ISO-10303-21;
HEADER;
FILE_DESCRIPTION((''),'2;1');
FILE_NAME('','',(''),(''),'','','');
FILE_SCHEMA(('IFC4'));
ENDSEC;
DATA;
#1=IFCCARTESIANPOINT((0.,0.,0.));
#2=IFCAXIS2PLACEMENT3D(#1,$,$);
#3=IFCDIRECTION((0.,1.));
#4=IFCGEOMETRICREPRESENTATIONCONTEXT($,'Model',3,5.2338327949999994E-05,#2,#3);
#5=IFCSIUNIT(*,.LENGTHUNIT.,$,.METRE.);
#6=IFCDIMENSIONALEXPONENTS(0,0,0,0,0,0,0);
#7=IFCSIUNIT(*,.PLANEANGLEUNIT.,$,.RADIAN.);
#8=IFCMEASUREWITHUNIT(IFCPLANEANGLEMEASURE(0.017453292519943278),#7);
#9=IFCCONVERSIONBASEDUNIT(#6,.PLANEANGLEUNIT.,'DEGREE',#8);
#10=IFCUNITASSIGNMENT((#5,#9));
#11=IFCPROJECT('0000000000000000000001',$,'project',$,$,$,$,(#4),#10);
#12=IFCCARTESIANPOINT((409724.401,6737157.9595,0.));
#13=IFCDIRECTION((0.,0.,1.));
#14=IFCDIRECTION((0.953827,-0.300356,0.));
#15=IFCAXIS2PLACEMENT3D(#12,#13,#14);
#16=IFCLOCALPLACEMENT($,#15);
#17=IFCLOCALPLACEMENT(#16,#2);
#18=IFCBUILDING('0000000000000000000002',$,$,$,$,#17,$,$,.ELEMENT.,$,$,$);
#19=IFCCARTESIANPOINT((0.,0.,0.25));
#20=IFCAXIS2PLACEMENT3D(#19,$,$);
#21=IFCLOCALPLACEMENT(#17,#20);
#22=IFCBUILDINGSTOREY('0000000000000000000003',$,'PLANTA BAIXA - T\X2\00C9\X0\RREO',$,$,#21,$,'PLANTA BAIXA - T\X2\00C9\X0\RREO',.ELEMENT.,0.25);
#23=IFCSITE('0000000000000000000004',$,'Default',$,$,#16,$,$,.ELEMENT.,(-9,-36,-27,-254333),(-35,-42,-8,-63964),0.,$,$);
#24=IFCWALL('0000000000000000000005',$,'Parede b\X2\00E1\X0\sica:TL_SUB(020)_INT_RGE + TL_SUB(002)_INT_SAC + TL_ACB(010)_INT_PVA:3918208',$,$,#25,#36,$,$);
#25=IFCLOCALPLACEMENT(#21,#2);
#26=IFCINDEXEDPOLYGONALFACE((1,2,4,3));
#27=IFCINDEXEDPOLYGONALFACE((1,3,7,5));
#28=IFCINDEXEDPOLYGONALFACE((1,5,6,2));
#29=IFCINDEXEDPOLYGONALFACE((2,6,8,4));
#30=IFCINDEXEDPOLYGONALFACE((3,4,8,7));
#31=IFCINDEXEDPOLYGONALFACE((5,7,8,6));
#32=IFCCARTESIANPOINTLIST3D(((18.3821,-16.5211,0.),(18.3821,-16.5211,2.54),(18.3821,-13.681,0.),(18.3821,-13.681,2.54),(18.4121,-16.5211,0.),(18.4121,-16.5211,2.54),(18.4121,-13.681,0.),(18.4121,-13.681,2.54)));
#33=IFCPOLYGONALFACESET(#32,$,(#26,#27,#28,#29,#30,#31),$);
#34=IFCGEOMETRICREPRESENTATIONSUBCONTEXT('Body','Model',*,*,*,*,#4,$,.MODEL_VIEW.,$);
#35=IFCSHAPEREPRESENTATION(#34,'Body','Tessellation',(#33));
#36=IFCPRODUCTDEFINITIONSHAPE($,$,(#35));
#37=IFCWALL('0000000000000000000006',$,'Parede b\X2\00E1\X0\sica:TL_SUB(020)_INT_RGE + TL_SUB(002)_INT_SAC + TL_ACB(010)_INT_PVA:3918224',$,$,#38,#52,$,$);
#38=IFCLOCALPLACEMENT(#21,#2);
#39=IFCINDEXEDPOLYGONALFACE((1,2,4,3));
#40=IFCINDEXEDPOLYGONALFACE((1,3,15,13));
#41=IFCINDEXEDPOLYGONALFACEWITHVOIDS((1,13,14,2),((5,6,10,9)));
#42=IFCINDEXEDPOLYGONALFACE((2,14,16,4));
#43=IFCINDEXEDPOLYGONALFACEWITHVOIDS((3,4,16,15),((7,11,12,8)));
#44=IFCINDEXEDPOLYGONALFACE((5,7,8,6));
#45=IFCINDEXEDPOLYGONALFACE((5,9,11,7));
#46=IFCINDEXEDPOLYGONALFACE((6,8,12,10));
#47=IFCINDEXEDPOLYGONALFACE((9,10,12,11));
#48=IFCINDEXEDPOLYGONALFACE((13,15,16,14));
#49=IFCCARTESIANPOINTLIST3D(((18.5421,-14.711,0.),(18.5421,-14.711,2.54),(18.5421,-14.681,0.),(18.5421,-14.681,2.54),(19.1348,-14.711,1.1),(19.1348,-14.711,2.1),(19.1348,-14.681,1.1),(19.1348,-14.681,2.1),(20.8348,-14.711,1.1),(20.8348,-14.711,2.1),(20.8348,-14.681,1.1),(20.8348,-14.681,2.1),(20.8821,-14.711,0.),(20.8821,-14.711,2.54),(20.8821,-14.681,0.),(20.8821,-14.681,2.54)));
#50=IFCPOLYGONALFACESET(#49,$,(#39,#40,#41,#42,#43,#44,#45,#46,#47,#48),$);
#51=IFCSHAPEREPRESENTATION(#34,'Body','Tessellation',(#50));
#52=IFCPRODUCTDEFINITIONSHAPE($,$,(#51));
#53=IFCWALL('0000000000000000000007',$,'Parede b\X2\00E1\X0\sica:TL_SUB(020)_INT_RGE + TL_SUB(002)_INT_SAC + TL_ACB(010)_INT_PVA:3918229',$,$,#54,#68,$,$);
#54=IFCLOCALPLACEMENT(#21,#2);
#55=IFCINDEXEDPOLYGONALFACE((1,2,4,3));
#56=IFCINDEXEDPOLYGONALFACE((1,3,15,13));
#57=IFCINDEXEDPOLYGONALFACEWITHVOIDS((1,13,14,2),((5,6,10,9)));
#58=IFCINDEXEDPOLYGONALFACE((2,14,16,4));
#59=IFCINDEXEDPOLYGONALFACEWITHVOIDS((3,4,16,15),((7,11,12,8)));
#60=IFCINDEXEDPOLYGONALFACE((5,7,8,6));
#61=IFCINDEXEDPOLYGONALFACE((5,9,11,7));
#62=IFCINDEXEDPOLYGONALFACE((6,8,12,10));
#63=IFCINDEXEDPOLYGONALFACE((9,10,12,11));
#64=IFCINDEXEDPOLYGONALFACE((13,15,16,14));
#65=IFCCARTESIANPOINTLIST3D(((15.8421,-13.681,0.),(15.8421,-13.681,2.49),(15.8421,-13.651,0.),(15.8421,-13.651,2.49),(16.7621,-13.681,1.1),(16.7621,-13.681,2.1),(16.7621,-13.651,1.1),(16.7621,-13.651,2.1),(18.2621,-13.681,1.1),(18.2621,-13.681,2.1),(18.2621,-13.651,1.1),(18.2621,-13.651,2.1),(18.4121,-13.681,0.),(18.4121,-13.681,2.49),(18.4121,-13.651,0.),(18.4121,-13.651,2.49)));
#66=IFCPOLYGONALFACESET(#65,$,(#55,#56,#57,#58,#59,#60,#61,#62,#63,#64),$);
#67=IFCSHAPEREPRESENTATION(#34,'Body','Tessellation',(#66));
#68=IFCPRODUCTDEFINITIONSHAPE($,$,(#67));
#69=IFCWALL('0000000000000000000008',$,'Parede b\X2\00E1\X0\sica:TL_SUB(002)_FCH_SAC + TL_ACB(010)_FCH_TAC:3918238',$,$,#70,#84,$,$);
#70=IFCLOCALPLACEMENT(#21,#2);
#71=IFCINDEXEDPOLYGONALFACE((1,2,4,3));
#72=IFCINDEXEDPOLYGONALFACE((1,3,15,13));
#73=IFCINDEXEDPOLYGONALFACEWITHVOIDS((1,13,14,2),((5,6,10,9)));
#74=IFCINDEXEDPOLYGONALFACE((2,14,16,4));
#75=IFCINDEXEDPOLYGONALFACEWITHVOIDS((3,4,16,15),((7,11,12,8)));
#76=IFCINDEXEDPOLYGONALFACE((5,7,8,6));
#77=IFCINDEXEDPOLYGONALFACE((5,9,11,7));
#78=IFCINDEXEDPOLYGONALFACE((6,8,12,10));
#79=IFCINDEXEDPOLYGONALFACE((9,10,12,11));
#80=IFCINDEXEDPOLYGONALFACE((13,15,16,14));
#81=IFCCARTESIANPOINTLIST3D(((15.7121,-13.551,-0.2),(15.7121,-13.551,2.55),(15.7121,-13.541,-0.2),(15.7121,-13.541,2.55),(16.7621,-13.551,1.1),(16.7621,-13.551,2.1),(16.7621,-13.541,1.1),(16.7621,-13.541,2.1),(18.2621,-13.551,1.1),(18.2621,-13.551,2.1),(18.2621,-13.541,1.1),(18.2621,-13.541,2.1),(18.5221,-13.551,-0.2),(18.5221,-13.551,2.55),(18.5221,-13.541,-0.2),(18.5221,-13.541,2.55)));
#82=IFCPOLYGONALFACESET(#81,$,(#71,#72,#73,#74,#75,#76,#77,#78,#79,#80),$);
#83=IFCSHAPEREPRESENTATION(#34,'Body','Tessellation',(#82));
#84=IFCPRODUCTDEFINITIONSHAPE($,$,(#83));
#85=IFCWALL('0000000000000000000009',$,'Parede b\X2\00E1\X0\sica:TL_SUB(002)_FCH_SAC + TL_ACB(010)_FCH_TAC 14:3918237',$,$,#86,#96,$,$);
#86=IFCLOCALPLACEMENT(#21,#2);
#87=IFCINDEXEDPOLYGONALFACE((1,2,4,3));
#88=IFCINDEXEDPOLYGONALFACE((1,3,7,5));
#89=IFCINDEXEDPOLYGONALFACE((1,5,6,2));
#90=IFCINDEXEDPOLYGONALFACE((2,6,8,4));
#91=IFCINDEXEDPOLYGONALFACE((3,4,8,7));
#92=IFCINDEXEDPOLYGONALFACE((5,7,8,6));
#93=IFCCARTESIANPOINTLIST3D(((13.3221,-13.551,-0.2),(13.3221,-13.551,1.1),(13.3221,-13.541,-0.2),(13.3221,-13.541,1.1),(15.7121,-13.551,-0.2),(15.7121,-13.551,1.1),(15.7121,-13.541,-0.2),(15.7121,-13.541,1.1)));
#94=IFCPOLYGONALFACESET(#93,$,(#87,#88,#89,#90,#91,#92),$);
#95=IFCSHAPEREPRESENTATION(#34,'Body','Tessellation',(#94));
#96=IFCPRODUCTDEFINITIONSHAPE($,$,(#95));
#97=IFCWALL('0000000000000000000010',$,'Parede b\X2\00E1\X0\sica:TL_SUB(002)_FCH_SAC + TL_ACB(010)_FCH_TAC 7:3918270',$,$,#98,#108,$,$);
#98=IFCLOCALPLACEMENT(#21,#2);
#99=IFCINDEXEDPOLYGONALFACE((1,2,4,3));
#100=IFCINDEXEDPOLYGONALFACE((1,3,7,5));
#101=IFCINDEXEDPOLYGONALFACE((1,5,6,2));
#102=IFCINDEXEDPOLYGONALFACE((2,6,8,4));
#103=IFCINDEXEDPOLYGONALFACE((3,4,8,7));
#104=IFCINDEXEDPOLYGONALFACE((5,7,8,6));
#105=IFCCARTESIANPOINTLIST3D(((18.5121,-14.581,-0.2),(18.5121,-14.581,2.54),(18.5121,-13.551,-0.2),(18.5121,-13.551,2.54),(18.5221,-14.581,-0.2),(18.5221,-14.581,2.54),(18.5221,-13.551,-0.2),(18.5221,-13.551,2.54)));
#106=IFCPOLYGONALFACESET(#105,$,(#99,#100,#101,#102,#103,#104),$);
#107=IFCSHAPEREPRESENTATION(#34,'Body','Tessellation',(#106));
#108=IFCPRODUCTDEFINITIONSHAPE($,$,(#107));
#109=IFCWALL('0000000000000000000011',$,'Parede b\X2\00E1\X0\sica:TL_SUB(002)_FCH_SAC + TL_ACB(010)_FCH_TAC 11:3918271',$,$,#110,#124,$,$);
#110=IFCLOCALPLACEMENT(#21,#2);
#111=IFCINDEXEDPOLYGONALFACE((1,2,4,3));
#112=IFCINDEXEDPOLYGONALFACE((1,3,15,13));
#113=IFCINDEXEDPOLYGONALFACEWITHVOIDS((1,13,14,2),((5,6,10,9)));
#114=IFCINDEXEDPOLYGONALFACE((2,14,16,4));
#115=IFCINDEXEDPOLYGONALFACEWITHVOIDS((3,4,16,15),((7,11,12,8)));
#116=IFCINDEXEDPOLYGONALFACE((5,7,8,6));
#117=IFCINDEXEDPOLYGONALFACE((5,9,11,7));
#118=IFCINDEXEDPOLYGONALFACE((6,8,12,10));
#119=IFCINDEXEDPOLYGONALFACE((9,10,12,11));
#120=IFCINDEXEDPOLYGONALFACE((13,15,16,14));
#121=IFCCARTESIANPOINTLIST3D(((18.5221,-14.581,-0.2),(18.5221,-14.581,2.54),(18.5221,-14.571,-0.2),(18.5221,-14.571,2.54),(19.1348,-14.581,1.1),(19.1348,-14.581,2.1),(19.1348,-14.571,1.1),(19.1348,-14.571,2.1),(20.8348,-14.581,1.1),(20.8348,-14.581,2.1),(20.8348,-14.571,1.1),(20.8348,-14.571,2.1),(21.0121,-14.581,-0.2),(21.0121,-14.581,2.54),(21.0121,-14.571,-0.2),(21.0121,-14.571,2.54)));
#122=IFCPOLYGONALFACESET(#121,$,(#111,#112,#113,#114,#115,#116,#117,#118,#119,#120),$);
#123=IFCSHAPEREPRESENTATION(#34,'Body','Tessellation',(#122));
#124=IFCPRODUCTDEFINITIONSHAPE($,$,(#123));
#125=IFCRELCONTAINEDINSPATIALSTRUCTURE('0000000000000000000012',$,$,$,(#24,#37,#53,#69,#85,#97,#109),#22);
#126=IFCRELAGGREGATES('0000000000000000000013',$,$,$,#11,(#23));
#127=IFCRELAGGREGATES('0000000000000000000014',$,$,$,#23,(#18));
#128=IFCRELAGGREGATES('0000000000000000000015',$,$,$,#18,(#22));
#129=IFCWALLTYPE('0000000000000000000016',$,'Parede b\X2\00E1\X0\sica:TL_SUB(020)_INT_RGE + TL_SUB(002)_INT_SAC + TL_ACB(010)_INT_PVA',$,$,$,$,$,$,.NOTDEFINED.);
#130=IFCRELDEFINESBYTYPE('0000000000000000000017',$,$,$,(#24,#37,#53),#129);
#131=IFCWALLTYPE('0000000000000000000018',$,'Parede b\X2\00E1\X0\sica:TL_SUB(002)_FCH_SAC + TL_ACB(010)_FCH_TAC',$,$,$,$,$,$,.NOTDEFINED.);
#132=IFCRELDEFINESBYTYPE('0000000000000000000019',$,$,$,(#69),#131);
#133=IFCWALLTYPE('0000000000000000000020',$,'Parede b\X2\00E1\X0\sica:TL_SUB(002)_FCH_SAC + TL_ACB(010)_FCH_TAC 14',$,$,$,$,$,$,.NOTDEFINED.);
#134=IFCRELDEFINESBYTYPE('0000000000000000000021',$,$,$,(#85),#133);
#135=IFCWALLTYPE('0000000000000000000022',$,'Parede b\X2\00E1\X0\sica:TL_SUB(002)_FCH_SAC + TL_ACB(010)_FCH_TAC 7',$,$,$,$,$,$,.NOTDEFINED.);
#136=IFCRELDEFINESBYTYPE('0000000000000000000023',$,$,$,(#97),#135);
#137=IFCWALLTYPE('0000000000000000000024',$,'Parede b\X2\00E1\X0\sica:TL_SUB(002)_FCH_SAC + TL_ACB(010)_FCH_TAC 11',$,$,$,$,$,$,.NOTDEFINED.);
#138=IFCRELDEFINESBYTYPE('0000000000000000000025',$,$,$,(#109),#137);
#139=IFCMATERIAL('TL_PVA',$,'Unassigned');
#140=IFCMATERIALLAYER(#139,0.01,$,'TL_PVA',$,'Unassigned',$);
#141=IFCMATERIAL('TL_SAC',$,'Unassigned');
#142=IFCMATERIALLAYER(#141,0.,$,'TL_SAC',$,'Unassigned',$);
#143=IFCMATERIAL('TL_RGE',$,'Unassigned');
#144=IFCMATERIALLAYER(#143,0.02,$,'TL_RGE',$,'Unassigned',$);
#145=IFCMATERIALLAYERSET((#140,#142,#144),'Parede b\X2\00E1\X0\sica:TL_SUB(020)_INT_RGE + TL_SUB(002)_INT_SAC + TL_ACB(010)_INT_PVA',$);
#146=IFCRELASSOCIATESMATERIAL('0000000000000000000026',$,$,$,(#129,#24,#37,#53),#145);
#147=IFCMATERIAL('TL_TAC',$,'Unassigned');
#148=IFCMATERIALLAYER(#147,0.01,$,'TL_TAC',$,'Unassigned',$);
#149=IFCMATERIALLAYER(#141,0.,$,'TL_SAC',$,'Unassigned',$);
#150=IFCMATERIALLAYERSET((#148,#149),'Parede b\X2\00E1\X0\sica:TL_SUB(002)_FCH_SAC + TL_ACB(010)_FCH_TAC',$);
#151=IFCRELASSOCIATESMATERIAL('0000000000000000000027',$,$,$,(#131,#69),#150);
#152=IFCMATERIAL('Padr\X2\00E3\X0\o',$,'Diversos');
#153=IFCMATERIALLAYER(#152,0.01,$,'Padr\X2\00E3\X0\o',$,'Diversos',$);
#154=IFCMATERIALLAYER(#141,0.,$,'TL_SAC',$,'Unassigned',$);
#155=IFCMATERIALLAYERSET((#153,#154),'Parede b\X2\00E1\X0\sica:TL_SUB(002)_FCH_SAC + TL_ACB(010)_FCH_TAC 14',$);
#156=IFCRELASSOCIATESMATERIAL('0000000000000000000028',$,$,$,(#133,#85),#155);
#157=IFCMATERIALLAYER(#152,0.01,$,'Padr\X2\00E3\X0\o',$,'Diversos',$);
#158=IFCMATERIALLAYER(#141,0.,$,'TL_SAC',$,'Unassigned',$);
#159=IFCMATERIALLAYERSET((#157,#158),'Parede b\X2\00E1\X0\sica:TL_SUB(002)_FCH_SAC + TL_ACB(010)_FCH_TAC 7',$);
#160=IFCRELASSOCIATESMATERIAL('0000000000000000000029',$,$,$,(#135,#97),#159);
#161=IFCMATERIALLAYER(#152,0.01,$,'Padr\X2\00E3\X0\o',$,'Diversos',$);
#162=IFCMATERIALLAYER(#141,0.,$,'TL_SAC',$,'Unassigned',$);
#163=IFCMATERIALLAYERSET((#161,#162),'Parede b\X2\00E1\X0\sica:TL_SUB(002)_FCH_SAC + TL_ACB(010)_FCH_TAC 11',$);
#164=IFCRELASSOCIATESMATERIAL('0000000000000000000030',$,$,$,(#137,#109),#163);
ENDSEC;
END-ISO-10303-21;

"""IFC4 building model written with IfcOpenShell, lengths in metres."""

from ifc_helpers import new_model, entity, si_unit, converted_unit, direction, frame, frame_2d, origin, place, context, subcontext, project, spatial, rectangle, extrude, material, layer, layer_set, layer_usage, type_object, element, save


model = new_model("IFC4")

# Units and contexts
model_context = context("Model", 3, precision=5.2338327949999994e-05, world=origin(), true_north=direction((0.0, 1.0)))
body_context = subcontext(model_context, "Body", "Model", "MODEL_VIEW")
ifc_project = project(units=[si_unit("LENGTHUNIT", "METRE"), converted_unit("PLANEANGLEUNIT", "DEGREE", entity("IfcPlaneAngleMeasure", 0.017453292519943278), si_unit("PLANEANGLEUNIT", "RADIAN"), dimensions=[0, 0, 0, 0, 0, 0, 0])], contexts=[model_context])

# Site, building, storey
site_placement = place(None, frame((409724.401, 6737157.9595, 0.0), z_axis=(0.0, 0.0, 1.0), x_axis=(0.953827, -0.300356, 0.0)))
site = spatial("IfcSite", under=ifc_project, at=site_placement, Name="Default", CompositionType="ELEMENT", RefLatitude=(-9, -36, -27, -254333), RefLongitude=(-35, -42, -8, -63964), RefElevation=0.0)
building_placement = place(site_placement, origin())
building = spatial("IfcBuilding", under=site, at=building_placement, CompositionType="ELEMENT")
storey_placement = place(building_placement, frame((0.0, 0.0, 0.25)))
storey = spatial("IfcBuildingStorey", under=building, at=storey_placement, Name="PLANTA BAIXA - TÉRREO", LongName="PLANTA BAIXA - TÉRREO", CompositionType="ELEMENT", Elevation=0.25)

# Shared definitions
ifc_material_1 = material(Name="TL_PVA", Category="Unassigned")
ifc_layer_1 = layer(ifc_material_1, 0.01, Name="TL_PVA", Category="Unassigned")
ifc_material_2 = material(Name="TL_SAC", Category="Unassigned")
ifc_layer_2 = layer(ifc_material_2, 0.0, Name="TL_SAC", Category="Unassigned")
ifc_material_3 = material(Name="TL_RGE", Category="Unassigned")
ifc_layer_3 = layer(ifc_material_3, 0.02, Name="TL_RGE", Category="Unassigned")
ifc_layer_set_1 = layer_set([ifc_layer_1, ifc_layer_2, ifc_layer_3], Name="Parede básica:TL_SUB(020)_INT_RGE + TL_SUB(002)_INT_SAC + TL_ACB(010)_INT_PVA")
wall_type_1 = type_object("IfcWallType", Name="Parede básica:TL_SUB(020)_INT_RGE + TL_SUB(002)_INT_SAC + TL_ACB(010)_INT_PVA", PredefinedType="NOTDEFINED", material=ifc_layer_set_1)

# Wall
ifc_layer_usage_1 = layer_usage(ifc_layer_set_1, "AXIS2", "POSITIVE", -0.015)
wall_1_placement = place(storey_placement, frame((18.3971, -13.681, 0.0), z_axis=(0.0, 0.0, 1.0), x_axis=(0.0, -1.0, 0.0)))
element("IfcWall", 1, at=wall_1_placement, inside=storey, type_object=wall_type_1, material=ifc_layer_usage_1, Name="Parede básica:TL_SUB(020)_INT_RGE + TL_SUB(002)_INT_SAC + TL_ACB(010)_INT_PVA:3918208", context=body_context, shape_type="SweptSolid", body=[
    extrude(rectangle(XDim=2.8401, YDim=0.03, at=frame_2d((1.4201, 0.0), x_axis=(-1.0, 0.0))), origin(), (0.0, 0.0, 1.0), 2.54),
])

# Walls, openings
ifc_layer_usage_2 = layer_usage(ifc_layer_set_1, "AXIS2", "POSITIVE", -0.015)
wall_2_placement = place(storey_placement, frame((18.5421, -14.696, 0.0)))
wall_2 = element("IfcWall", 2, at=wall_2_placement, inside=storey, type_object=wall_type_1, material=ifc_layer_usage_2, Name="Parede básica:TL_SUB(020)_INT_RGE + TL_SUB(002)_INT_SAC + TL_ACB(010)_INT_PVA:3918224", context=body_context, shape_type="SweptSolid", body=[
    extrude(rectangle(XDim=2.34, YDim=0.03, at=frame_2d((1.17, 0.0), x_axis=(-1.0, 0.0))), origin(), (0.0, 0.0, 1.0), 2.54),
])
opening_1_placement = place(wall_2_placement, frame((-18.5421, 14.696, 1.1)))
element("IfcOpeningElement", 3, at=opening_1_placement, cuts=wall_2, PredefinedType="OPENING", context=body_context, shape_type="SweptSolid", body=[
    extrude(rectangle(XDim=1.0, YDim=1.7, at=frame_2d((0.0, 0.0), x_axis=(0.0, 1.0))), frame((19.9848, -16.205, 0.5), z_axis=(0.0, 1.0, 0.0), x_axis=(1.0, 0.0, 0.0)), (0.0, 0.0, 1.0), 3.048),
])
ifc_layer_usage_3 = layer_usage(ifc_layer_set_1, "AXIS2", "POSITIVE", -0.015)
wall_3_placement = place(storey_placement, frame((15.8421, -13.666, 0.0)))
wall_3 = element("IfcWall", 4, at=wall_3_placement, inside=storey, type_object=wall_type_1, material=ifc_layer_usage_3, Name="Parede básica:TL_SUB(020)_INT_RGE + TL_SUB(002)_INT_SAC + TL_ACB(010)_INT_PVA:3918229", context=body_context, shape_type="SweptSolid", body=[
    extrude(rectangle(XDim=2.57, YDim=0.03, at=frame_2d((1.285, 0.0), x_axis=(-1.0, 0.0))), origin(), (0.0, 0.0, 1.0), 2.49),
])
opening_2_placement = place(wall_3_placement, frame((-15.8421, 13.666, 1.1)))
element("IfcOpeningElement", 5, at=opening_2_placement, cuts=wall_3, PredefinedType="OPENING", context=body_context, shape_type="SweptSolid", body=[
    extrude(rectangle(XDim=1.0, YDim=1.5, at=frame_2d((0.0, 0.0), x_axis=(0.0, 1.0))), frame((17.5121, -15.175, 0.5), z_axis=(0.0, 1.0, 0.0), x_axis=(1.0, 0.0, 0.0)), (0.0, 0.0, 1.0), 3.048),
])
ifc_material_4 = material(Name="TL_TAC", Category="Unassigned")
ifc_layer_4 = layer(ifc_material_4, 0.01, Name="TL_TAC", Category="Unassigned")
ifc_layer_5 = layer(ifc_material_2, 0.0, Name="TL_SAC", Category="Unassigned")
ifc_layer_set_2 = layer_set([ifc_layer_4, ifc_layer_5], Name="Parede básica:TL_SUB(002)_FCH_SAC + TL_ACB(010)_FCH_TAC")
ifc_layer_usage_4 = layer_usage(ifc_layer_set_2, "AXIS2", "NEGATIVE", 0.005)
wall_type_2 = type_object("IfcWallType", Name="Parede básica:TL_SUB(002)_FCH_SAC + TL_ACB(010)_FCH_TAC", PredefinedType="NOTDEFINED", material=ifc_layer_set_2)
wall_4_placement = place(storey_placement, frame((15.7121, -13.546, -0.2)))
wall_4 = element("IfcWall", 6, at=wall_4_placement, inside=storey, type_object=wall_type_2, material=ifc_layer_usage_4, Name="Parede básica:TL_SUB(002)_FCH_SAC + TL_ACB(010)_FCH_TAC:3918238", context=body_context, shape_type="SweptSolid", body=[
    extrude(rectangle(XDim=2.81, YDim=0.01, at=frame_2d((1.405, 0.0), x_axis=(-1.0, 0.0))), origin(), (0.0, 0.0, 1.0), 2.75),
])
opening_3_placement = place(wall_4_placement, frame((-15.7121, 13.546, 1.3)))
element("IfcOpeningElement", 7, at=opening_3_placement, cuts=wall_4, PredefinedType="OPENING", context=body_context, shape_type="SweptSolid", body=[
    extrude(rectangle(XDim=1.0, YDim=1.5, at=frame_2d((0.0, 0.0), x_axis=(0.0, 1.0))), frame((17.5121, -15.175, 0.5), z_axis=(0.0, 1.0, 0.0), x_axis=(1.0, 0.0, 0.0)), (0.0, 0.0, 1.0), 3.048),
])

# Walls
ifc_material_5 = material(Name="Padrão", Category="Diversos")
ifc_layer_6 = layer(ifc_material_5, 0.01, Name="Padrão", Category="Diversos")
ifc_layer_7 = layer(ifc_material_2, 0.0, Name="TL_SAC", Category="Unassigned")
ifc_layer_set_3 = layer_set([ifc_layer_6, ifc_layer_7], Name="Parede básica:TL_SUB(002)_FCH_SAC + TL_ACB(010)_FCH_TAC 14")
ifc_layer_usage_5 = layer_usage(ifc_layer_set_3, "AXIS2", "POSITIVE", -0.005)
wall_type_3 = type_object("IfcWallType", Name="Parede básica:TL_SUB(002)_FCH_SAC + TL_ACB(010)_FCH_TAC 14", PredefinedType="NOTDEFINED", material=ifc_layer_set_3)
wall_5_placement = place(storey_placement, frame((13.3221, -13.546, -0.2)))
element("IfcWall", 8, at=wall_5_placement, inside=storey, type_object=wall_type_3, material=ifc_layer_usage_5, Name="Parede básica:TL_SUB(002)_FCH_SAC + TL_ACB(010)_FCH_TAC 14:3918237", context=body_context, shape_type="SweptSolid", body=[
    extrude(rectangle(XDim=2.39, YDim=0.01, at=frame_2d((1.195, 0.0), x_axis=(-1.0, 0.0))), origin(), (0.0, 0.0, 1.0), 1.3),
])
ifc_layer_8 = layer(ifc_material_5, 0.01, Name="Padrão", Category="Diversos")
ifc_layer_9 = layer(ifc_material_2, 0.0, Name="TL_SAC", Category="Unassigned")
ifc_layer_set_4 = layer_set([ifc_layer_8, ifc_layer_9], Name="Parede básica:TL_SUB(002)_FCH_SAC + TL_ACB(010)_FCH_TAC 7")
ifc_layer_usage_6 = layer_usage(ifc_layer_set_4, "AXIS2", "POSITIVE", -0.005)
wall_type_4 = type_object("IfcWallType", Name="Parede básica:TL_SUB(002)_FCH_SAC + TL_ACB(010)_FCH_TAC 7", PredefinedType="NOTDEFINED", material=ifc_layer_set_4)
wall_6_placement = place(storey_placement, frame((18.5171, -13.551, -0.2), z_axis=(0.0, 0.0, 1.0), x_axis=(0.0, -1.0, 0.0)))
element("IfcWall", 9, at=wall_6_placement, inside=storey, type_object=wall_type_4, material=ifc_layer_usage_6, Name="Parede básica:TL_SUB(002)_FCH_SAC + TL_ACB(010)_FCH_TAC 7:3918270", context=body_context, shape_type="SweptSolid", body=[
    extrude(rectangle(XDim=1.03, YDim=0.01, at=frame_2d((0.515, 0.0), x_axis=(-1.0, 0.0))), origin(), (0.0, 0.0, 1.0), 2.74),
])

# Wall, opening
ifc_layer_10 = layer(ifc_material_5, 0.01, Name="Padrão", Category="Diversos")
ifc_layer_11 = layer(ifc_material_2, 0.0, Name="TL_SAC", Category="Unassigned")
ifc_layer_set_5 = layer_set([ifc_layer_10, ifc_layer_11], Name="Parede básica:TL_SUB(002)_FCH_SAC + TL_ACB(010)_FCH_TAC 11")
ifc_layer_usage_7 = layer_usage(ifc_layer_set_5, "AXIS2", "POSITIVE", -0.005)
wall_type_5 = type_object("IfcWallType", Name="Parede básica:TL_SUB(002)_FCH_SAC + TL_ACB(010)_FCH_TAC 11", PredefinedType="NOTDEFINED", material=ifc_layer_set_5)
wall_7_placement = place(storey_placement, frame((18.5221, -14.576, -0.2)))
wall_7 = element("IfcWall", 10, at=wall_7_placement, inside=storey, type_object=wall_type_5, material=ifc_layer_usage_7, Name="Parede básica:TL_SUB(002)_FCH_SAC + TL_ACB(010)_FCH_TAC 11:3918271", context=body_context, shape_type="SweptSolid", body=[
    extrude(rectangle(XDim=2.49, YDim=0.01, at=frame_2d((1.245, 0.0), x_axis=(-1.0, 0.0))), origin(), (0.0, 0.0, 1.0), 2.74),
])
opening_4_placement = place(wall_7_placement, frame((-18.5221, 14.576, 1.3)))
element("IfcOpeningElement", 11, at=opening_4_placement, cuts=wall_7, PredefinedType="OPENING", context=body_context, shape_type="SweptSolid", body=[
    extrude(rectangle(XDim=1.0, YDim=1.7, at=frame_2d((0.0, 0.0), x_axis=(0.0, 1.0))), frame((19.9848, -16.205, 0.5), z_axis=(0.0, 1.0, 0.0), x_axis=(1.0, 0.0, 0.0)), (0.0, 0.0, 1.0), 3.048),
])

save(model, "model.ifc")
